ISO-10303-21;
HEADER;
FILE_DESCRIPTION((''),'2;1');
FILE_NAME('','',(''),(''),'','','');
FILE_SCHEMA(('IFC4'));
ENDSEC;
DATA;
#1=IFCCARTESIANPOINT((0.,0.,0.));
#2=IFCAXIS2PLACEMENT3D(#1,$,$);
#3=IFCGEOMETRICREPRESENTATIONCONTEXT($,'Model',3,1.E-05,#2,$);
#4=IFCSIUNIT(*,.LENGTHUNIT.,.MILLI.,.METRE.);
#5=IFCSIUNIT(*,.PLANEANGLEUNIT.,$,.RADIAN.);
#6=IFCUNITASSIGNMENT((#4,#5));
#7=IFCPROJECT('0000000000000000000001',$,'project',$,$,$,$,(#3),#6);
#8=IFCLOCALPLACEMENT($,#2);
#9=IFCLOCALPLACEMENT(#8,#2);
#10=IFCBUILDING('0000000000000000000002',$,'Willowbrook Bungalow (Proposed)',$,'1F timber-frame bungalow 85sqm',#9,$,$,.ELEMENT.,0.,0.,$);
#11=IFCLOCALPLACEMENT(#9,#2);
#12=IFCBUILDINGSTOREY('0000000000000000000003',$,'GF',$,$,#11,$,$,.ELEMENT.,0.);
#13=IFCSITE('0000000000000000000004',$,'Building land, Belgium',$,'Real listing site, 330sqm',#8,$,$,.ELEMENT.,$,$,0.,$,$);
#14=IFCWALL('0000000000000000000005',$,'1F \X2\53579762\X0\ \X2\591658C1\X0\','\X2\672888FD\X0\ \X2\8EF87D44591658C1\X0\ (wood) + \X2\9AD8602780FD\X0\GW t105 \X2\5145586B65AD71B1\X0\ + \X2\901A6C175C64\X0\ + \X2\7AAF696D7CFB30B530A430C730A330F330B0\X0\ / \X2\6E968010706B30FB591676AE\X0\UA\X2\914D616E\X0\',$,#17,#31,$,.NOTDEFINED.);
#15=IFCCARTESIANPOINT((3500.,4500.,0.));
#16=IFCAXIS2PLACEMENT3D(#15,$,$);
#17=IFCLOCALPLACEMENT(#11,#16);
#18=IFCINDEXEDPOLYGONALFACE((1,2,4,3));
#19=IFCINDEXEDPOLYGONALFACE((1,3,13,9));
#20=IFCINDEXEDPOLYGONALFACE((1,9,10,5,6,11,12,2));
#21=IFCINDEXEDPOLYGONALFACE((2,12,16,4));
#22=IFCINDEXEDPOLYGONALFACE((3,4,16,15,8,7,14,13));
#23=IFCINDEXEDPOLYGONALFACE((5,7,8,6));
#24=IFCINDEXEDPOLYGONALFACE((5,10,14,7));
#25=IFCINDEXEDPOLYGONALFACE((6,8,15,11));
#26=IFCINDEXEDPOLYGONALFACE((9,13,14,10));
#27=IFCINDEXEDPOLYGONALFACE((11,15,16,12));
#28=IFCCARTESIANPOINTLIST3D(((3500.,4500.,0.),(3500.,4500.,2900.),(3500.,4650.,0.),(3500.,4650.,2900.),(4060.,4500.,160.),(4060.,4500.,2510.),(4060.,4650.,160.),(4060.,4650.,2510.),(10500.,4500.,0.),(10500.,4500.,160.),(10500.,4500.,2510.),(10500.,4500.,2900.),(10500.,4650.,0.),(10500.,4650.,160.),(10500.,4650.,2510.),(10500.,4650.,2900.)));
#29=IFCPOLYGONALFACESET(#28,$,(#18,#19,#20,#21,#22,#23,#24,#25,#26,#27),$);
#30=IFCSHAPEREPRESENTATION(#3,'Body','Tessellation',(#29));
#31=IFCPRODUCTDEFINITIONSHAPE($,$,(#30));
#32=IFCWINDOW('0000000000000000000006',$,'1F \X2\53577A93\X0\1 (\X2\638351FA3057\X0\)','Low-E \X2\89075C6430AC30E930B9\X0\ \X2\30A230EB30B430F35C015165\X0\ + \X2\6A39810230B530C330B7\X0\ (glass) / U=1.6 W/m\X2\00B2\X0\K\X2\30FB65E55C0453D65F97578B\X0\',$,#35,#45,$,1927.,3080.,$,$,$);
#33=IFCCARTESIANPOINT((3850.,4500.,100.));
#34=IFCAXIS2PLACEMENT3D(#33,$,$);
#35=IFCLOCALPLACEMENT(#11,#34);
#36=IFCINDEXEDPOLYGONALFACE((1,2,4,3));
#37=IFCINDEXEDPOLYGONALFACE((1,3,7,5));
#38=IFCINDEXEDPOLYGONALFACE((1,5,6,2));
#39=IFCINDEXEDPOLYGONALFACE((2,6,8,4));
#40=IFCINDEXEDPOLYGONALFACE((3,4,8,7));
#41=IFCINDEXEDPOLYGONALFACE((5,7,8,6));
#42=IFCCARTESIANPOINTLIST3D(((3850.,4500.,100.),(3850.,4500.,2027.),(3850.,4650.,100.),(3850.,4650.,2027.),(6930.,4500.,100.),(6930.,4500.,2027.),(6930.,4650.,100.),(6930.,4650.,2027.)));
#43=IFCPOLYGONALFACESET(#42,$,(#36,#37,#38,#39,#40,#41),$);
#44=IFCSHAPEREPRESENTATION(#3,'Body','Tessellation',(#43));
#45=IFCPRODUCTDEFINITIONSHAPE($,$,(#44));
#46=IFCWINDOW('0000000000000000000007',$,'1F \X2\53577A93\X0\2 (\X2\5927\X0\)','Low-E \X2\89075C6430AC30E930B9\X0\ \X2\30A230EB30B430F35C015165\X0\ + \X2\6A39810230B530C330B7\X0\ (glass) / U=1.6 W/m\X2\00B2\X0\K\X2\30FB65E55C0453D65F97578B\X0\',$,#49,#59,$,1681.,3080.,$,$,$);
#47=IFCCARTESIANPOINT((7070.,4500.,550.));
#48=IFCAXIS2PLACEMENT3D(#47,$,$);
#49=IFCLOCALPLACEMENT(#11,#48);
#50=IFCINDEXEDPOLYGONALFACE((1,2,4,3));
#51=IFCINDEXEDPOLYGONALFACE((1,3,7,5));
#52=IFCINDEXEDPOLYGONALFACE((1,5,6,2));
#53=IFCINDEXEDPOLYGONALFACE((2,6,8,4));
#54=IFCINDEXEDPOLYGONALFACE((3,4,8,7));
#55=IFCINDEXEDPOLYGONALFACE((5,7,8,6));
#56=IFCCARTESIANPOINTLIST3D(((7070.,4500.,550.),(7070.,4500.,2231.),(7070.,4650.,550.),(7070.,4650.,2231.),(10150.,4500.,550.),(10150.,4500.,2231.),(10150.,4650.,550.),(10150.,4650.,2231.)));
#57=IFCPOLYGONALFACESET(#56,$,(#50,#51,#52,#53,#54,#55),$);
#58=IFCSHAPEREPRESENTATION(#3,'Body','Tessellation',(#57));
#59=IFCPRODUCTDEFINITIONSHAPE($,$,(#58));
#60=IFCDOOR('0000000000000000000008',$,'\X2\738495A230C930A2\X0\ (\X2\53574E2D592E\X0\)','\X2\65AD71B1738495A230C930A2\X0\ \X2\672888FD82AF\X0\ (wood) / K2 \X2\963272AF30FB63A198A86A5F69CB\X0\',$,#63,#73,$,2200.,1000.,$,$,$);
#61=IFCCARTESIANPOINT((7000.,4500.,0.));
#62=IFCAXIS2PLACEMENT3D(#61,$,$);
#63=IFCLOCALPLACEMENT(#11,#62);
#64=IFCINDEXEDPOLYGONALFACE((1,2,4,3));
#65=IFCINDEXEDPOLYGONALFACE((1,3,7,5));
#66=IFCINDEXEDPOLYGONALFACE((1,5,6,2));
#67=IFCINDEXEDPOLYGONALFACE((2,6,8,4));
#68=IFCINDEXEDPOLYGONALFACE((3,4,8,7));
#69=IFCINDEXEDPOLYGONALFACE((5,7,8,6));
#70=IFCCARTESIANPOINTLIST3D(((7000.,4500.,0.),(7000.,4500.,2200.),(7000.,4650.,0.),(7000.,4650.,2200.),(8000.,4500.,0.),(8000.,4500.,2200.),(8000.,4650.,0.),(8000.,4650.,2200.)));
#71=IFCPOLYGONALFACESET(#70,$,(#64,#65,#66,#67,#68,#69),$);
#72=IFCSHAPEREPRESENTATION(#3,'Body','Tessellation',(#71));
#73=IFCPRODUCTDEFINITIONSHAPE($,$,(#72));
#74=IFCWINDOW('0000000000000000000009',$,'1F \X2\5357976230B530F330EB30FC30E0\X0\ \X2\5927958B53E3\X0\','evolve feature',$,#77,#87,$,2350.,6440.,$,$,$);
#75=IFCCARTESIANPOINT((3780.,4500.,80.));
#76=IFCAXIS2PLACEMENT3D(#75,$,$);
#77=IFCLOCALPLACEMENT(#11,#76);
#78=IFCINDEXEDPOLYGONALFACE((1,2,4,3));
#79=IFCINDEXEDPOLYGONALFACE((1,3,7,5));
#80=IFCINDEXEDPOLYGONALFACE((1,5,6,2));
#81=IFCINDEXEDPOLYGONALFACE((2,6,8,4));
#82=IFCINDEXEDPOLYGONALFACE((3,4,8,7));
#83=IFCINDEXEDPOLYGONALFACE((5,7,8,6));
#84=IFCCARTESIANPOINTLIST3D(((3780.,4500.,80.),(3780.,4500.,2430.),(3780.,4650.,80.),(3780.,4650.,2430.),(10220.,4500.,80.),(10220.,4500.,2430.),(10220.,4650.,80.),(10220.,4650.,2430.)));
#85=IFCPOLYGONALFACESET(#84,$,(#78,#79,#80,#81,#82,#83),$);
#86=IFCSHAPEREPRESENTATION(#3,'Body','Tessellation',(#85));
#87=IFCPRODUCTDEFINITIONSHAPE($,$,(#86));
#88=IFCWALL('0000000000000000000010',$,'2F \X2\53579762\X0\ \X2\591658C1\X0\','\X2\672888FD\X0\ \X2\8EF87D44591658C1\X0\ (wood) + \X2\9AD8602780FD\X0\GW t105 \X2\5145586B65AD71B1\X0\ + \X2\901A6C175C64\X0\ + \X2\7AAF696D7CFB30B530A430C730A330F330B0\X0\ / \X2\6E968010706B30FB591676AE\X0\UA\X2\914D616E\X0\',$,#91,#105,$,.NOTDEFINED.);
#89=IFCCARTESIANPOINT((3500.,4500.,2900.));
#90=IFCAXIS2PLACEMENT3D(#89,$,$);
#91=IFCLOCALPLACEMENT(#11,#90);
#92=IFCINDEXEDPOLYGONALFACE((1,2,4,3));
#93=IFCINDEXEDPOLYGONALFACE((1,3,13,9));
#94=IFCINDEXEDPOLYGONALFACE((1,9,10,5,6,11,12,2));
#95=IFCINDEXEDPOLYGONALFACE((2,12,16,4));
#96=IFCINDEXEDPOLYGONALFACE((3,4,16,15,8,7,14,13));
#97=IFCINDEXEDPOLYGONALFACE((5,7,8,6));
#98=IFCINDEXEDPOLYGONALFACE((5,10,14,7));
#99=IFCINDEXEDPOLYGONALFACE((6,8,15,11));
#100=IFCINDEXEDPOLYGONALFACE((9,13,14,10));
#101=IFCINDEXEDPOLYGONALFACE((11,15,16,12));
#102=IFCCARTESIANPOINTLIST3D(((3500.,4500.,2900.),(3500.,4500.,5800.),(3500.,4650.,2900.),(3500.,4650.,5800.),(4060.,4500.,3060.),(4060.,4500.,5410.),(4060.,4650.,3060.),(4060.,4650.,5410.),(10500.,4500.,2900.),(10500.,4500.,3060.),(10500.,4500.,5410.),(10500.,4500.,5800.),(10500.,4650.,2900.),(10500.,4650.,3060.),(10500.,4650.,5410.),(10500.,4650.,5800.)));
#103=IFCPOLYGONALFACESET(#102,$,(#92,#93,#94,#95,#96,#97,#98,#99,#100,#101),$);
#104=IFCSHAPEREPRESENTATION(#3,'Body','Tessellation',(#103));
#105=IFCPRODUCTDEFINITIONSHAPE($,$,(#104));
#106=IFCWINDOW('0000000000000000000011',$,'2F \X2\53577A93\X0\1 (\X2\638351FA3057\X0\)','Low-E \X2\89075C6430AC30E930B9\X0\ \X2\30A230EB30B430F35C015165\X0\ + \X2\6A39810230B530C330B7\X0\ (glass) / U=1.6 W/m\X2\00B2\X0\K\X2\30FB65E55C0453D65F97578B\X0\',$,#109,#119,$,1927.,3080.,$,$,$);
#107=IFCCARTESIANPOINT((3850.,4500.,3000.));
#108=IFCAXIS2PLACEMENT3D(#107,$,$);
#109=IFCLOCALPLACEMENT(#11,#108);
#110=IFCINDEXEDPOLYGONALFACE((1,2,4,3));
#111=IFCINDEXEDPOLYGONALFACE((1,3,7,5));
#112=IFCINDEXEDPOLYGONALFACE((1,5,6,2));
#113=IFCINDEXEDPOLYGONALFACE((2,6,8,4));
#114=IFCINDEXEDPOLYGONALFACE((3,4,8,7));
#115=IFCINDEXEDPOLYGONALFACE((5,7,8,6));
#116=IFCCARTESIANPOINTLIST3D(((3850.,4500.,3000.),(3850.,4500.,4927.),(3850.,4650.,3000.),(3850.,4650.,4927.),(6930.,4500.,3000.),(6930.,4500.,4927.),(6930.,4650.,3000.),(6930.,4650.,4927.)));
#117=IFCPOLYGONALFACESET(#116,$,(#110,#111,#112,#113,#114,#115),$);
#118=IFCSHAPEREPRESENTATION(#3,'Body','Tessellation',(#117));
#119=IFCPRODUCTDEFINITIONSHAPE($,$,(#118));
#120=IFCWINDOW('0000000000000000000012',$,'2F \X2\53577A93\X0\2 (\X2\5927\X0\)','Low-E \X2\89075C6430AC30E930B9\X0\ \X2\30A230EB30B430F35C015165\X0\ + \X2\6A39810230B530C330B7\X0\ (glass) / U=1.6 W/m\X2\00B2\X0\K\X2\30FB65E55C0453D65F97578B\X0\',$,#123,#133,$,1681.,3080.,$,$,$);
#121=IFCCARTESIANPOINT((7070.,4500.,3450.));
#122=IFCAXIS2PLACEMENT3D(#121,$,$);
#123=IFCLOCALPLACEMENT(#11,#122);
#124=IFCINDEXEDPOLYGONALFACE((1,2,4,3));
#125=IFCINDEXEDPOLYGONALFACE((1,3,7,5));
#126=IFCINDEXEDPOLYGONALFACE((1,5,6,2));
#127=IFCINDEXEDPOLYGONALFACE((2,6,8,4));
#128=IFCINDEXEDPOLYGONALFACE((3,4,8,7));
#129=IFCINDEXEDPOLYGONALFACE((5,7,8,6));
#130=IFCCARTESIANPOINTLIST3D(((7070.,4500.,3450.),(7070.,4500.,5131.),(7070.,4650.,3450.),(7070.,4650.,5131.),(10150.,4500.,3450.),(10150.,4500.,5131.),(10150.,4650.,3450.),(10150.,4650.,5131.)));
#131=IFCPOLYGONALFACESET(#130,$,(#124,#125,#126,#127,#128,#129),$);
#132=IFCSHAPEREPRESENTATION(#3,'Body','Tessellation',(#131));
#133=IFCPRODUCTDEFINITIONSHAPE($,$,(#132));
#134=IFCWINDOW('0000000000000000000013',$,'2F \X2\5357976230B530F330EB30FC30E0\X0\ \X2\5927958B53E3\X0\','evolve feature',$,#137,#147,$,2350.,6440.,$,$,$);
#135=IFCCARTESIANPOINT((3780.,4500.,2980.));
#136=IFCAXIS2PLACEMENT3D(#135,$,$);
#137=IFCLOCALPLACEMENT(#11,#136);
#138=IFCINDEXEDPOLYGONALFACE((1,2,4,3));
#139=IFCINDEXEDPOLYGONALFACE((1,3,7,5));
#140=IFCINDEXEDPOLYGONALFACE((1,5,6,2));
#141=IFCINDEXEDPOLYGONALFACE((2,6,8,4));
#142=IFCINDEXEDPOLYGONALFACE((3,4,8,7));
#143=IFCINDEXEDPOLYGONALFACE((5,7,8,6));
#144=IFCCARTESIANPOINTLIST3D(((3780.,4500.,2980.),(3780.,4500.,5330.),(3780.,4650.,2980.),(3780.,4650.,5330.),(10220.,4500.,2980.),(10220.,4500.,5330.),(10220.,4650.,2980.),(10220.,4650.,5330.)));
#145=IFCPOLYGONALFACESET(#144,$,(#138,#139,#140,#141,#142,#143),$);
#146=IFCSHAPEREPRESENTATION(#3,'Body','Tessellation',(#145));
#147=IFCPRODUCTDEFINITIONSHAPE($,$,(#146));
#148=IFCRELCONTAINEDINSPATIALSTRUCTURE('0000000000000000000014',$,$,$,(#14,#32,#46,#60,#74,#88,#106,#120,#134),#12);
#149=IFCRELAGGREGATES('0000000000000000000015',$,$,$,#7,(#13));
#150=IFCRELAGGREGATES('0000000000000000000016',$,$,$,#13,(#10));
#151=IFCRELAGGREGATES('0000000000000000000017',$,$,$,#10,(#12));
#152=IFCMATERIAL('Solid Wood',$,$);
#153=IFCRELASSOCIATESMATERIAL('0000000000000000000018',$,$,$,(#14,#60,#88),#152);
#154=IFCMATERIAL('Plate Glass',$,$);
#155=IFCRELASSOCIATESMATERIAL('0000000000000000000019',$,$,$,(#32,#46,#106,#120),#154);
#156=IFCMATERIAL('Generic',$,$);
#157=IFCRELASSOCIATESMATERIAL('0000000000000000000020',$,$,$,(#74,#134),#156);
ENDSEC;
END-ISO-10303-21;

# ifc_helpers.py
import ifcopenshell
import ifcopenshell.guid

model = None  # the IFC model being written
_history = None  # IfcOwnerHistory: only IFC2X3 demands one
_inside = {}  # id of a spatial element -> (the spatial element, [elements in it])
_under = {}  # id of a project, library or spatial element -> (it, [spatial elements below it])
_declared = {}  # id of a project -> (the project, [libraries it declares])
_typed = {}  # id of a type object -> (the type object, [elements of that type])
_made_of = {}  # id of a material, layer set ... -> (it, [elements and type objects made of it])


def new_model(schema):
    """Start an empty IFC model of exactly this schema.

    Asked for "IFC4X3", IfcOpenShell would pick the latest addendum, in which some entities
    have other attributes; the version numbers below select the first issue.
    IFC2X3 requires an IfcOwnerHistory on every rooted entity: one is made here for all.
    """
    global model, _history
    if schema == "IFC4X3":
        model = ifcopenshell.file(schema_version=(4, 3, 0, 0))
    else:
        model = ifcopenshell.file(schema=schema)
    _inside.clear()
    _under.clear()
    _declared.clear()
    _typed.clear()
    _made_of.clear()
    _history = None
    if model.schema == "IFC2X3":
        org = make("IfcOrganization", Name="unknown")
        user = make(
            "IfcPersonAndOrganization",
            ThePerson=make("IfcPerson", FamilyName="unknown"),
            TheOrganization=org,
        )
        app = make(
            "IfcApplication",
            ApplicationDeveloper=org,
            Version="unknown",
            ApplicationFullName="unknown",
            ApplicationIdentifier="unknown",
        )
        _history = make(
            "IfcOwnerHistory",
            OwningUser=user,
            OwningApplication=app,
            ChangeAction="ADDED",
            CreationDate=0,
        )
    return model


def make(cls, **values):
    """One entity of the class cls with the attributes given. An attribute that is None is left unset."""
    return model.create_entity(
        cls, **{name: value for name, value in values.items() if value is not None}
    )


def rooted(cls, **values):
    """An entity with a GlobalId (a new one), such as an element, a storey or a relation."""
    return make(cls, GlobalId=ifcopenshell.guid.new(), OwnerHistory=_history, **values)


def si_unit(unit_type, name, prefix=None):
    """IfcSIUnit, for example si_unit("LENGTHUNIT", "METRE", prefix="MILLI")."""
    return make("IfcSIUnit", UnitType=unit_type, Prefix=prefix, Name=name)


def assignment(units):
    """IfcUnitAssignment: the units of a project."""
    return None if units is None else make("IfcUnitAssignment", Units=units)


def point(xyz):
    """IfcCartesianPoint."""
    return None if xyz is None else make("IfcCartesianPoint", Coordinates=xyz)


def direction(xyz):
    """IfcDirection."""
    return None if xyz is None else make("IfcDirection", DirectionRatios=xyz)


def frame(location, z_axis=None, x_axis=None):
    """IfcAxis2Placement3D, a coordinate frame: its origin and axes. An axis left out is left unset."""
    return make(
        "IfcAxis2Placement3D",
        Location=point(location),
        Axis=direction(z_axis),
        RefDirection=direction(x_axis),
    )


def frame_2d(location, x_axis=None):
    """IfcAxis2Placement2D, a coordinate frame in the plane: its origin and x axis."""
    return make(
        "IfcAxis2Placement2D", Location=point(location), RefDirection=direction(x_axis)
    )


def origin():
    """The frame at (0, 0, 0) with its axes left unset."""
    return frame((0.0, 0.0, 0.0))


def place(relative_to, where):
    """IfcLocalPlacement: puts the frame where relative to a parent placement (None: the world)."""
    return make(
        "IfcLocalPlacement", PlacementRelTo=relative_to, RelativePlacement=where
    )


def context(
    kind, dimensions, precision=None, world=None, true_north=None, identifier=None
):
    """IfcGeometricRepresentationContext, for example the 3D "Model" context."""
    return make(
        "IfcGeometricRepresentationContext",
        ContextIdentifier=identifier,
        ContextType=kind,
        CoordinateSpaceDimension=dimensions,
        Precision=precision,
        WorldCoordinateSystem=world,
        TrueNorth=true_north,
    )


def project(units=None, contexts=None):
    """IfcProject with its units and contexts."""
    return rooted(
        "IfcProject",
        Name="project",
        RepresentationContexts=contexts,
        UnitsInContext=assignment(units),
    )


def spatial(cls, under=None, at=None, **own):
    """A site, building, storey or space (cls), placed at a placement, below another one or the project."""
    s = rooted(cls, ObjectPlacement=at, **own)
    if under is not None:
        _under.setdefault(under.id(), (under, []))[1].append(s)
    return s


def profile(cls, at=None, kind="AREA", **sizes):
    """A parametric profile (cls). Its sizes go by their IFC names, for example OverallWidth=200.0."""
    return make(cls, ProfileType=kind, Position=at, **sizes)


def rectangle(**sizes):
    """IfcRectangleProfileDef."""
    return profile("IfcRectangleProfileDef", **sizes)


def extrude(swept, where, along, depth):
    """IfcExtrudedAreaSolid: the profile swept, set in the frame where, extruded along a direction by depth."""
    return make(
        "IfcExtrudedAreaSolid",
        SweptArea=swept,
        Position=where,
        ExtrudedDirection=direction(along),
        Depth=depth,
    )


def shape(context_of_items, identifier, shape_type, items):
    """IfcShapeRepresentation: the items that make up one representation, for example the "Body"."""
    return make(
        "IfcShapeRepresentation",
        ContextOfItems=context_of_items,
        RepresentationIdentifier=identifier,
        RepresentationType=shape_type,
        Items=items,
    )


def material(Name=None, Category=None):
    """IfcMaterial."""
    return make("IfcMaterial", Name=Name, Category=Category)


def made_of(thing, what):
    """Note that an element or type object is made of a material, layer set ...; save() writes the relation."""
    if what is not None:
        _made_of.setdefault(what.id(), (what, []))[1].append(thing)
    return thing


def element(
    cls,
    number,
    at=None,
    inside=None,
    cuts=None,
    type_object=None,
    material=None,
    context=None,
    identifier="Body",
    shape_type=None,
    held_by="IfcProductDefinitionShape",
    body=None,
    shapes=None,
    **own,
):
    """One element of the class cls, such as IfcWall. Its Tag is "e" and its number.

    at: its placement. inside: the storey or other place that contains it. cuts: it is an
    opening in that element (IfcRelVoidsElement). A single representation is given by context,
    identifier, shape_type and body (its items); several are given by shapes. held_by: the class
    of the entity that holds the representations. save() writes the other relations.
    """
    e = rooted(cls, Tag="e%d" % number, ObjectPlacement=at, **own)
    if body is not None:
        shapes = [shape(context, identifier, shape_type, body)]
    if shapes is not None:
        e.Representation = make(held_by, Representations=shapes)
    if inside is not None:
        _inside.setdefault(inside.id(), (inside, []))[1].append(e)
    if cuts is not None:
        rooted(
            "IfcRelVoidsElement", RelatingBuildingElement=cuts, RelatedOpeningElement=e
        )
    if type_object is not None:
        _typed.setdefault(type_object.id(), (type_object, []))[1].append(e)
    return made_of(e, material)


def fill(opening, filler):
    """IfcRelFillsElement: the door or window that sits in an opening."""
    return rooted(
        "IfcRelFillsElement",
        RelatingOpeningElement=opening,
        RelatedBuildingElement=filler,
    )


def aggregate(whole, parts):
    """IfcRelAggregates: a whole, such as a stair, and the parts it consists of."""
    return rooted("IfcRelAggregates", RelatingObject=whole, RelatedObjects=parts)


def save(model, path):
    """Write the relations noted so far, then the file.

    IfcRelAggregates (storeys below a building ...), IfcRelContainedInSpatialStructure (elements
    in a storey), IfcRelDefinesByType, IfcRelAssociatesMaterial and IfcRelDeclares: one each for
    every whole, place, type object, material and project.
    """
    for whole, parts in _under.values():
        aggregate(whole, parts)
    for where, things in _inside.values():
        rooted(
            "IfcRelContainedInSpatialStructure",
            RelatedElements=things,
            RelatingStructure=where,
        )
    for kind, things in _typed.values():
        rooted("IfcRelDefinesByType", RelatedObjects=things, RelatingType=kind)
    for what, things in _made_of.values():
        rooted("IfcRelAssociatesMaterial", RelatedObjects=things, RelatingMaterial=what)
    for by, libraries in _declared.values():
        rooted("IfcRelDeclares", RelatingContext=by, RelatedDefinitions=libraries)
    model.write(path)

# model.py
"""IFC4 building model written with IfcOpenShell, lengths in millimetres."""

from ifc_helpers import new_model, si_unit, frame, frame_2d, origin, place, context, project, spatial, rectangle, extrude, material, element, fill, save


model = new_model("IFC4")

# Units and contexts
model_context = context("Model", 3, precision=1e-05, world=origin())
ifc_project = project(units=[si_unit("LENGTHUNIT", "METRE", prefix="MILLI"), si_unit("PLANEANGLEUNIT", "RADIAN")], contexts=[model_context])

# Site, building, storey
site_placement = place(None, origin())
site = spatial("IfcSite", under=ifc_project, at=site_placement, Name="Building land, Belgium", ObjectType="Real listing site, 330sqm", CompositionType="ELEMENT", RefElevation=0.0)
building_placement = place(site_placement, origin())
building = spatial("IfcBuilding", under=site, at=building_placement, Name="Willowbrook Bungalow (Proposed)", ObjectType="1F timber-frame bungalow 85sqm", CompositionType="ELEMENT", ElevationOfRefHeight=0.0, ElevationOfTerrain=0.0)
storey_placement = place(building_placement, origin())
storey = spatial("IfcBuildingStorey", under=building, at=storey_placement, Name="GF", CompositionType="ELEMENT", Elevation=0.0)

# Shared definitions
ifc_material_1 = material(Name="Solid Wood")
ifc_material_2 = material(Name="Generic")

# Wall, openings, windows, door
wall_1_placement = place(storey_placement, frame((3500.0, 4500.0, 0.0)))
wall_1 = element("IfcWall", 1, at=wall_1_placement, inside=storey, material=ifc_material_1, Name="1F 南面 外壁", Description="木製 軸組外壁 (wood) + 高性能GW t105 充填断熱 + 通気層 + 窯業系サイディング / 準耐火・外皮UA配慮", PredefinedType="NOTDEFINED", context=model_context, shape_type="SweptSolid", body=[
    extrude(rectangle(XDim=7000.0, YDim=150.0, at=frame_2d((3500.0, 75.0))), frame((3500.0, 4500.0, 0.0)), (0.0, 0.0, 1.0), 2900.0),
])
opening_1_placement = place(storey_placement, frame((3850.0, 4500.0, 100.0)))
opening_1 = element("IfcOpeningElement", 2, at=opening_1_placement, cuts=wall_1, PredefinedType="NOTDEFINED", context=model_context, shape_type="SweptSolid", body=[
    extrude(rectangle(XDim=3080.0, YDim=150.0, at=frame_2d((1540.0, 75.0))), frame((3850.0, 4500.0, 100.0)), (0.0, 0.0, 1.0), 1927.0),
])
opening_2_placement = place(storey_placement, frame((7070.0, 4500.0, 550.0)))
opening_2 = element("IfcOpeningElement", 3, at=opening_2_placement, cuts=wall_1, PredefinedType="NOTDEFINED", context=model_context, shape_type="SweptSolid", body=[
    extrude(rectangle(XDim=3080.0, YDim=150.0, at=frame_2d((1540.0, 75.0))), frame((7070.0, 4500.0, 550.0)), (0.0, 0.0, 1.0), 1681.0),
])
opening_3_placement = place(storey_placement, frame((7000.0, 4500.0, 0.0)))
opening_3 = element("IfcOpeningElement", 4, at=opening_3_placement, cuts=wall_1, PredefinedType="NOTDEFINED", context=model_context, shape_type="SweptSolid", body=[
    extrude(rectangle(XDim=1000.0, YDim=150.0, at=frame_2d((500.0, 75.0))), frame((7000.0, 4500.0, 0.0)), (0.0, 0.0, 1.0), 2200.0),
])
opening_4_placement = place(storey_placement, frame((3780.0, 4500.0, 80.0)))
opening_4 = element("IfcOpeningElement", 5, at=opening_4_placement, cuts=wall_1, PredefinedType="NOTDEFINED", context=model_context, shape_type="SweptSolid", body=[
    extrude(rectangle(XDim=6440.0, YDim=150.0, at=frame_2d((3220.0, 75.0))), frame((3780.0, 4500.0, 80.0)), (0.0, 0.0, 1.0), 2350.0),
])
ifc_material_3 = material(Name="Plate Glass")
window_1_placement = place(storey_placement, frame((3850.0, 4500.0, 100.0)))
window_1 = element("IfcWindow", 6, at=window_1_placement, inside=storey, material=ifc_material_3, Name="1F 南窓1 (掃出し)", Description="Low-E 複層ガラス アルゴン封入 + 樹脂サッシ (glass) / U=1.6 W/m²K・日射取得型", OverallHeight=1927.0, OverallWidth=3080.0, context=model_context, shape_type="SweptSolid", body=[
    extrude(rectangle(XDim=3080.0, YDim=150.0, at=frame_2d((1540.0, 75.0))), frame((3850.0, 4500.0, 100.0)), (0.0, 0.0, 1.0), 1927.0),
])
fill(opening_1, window_1)
window_2_placement = place(storey_placement, frame((7070.0, 4500.0, 550.0)))
window_2 = element("IfcWindow", 7, at=window_2_placement, inside=storey, material=ifc_material_3, Name="1F 南窓2 (大)", Description="Low-E 複層ガラス アルゴン封入 + 樹脂サッシ (glass) / U=1.6 W/m²K・日射取得型", OverallHeight=1681.0, OverallWidth=3080.0, context=model_context, shape_type="SweptSolid", body=[
    extrude(rectangle(XDim=3080.0, YDim=150.0, at=frame_2d((1540.0, 75.0))), frame((7070.0, 4500.0, 550.0)), (0.0, 0.0, 1.0), 1681.0),
])
fill(opening_2, window_2)
door_placement = place(storey_placement, frame((7000.0, 4500.0, 0.0)))
door = element("IfcDoor", 8, at=door_placement, inside=storey, material=ifc_material_1, Name="玄関ドア (南中央)", Description="断熱玄関ドア 木製芯 (wood) / K2 防犯・採風機構", OverallHeight=2200.0, OverallWidth=1000.0, context=model_context, shape_type="SweptSolid", body=[
    extrude(rectangle(XDim=1000.0, YDim=150.0, at=frame_2d((500.0, 75.0))), frame((7000.0, 4500.0, 0.0)), (0.0, 0.0, 1.0), 2200.0),
])
fill(opening_3, door)
window_3_placement = place(storey_placement, frame((3780.0, 4500.0, 80.0)))
window_3 = element("IfcWindow", 9, at=window_3_placement, inside=storey, material=ifc_material_2, Name="1F 南面サンルーム 大開口", Description="evolve feature", OverallHeight=2350.0, OverallWidth=6440.0, context=model_context, shape_type="SweptSolid", body=[
    extrude(rectangle(XDim=6440.0, YDim=150.0, at=frame_2d((3220.0, 75.0))), frame((3780.0, 4500.0, 80.0)), (0.0, 0.0, 1.0), 2350.0),
])
fill(opening_4, window_3)

# Wall, openings, windows
wall_2_placement = place(storey_placement, frame((3500.0, 4500.0, 2900.0)))
wall_2 = element("IfcWall", 10, at=wall_2_placement, inside=storey, material=ifc_material_1, Name="2F 南面 外壁", Description="木製 軸組外壁 (wood) + 高性能GW t105 充填断熱 + 通気層 + 窯業系サイディング / 準耐火・外皮UA配慮", PredefinedType="NOTDEFINED", context=model_context, shape_type="SweptSolid", body=[
    extrude(rectangle(XDim=7000.0, YDim=150.0, at=frame_2d((3500.0, 75.0))), frame((3500.0, 4500.0, 2900.0)), (0.0, 0.0, 1.0), 2900.0),
])
opening_5_placement = place(storey_placement, frame((3850.0, 4500.0, 3000.0)))
opening_5 = element("IfcOpeningElement", 11, at=opening_5_placement, cuts=wall_2, PredefinedType="NOTDEFINED", context=model_context, shape_type="SweptSolid", body=[
    extrude(rectangle(XDim=3080.0, YDim=150.0, at=frame_2d((1540.0, 75.0))), frame((3850.0, 4500.0, 3000.0)), (0.0, 0.0, 1.0), 1927.0),
])
opening_6_placement = place(storey_placement, frame((7070.0, 4500.0, 3450.0)))
opening_6 = element("IfcOpeningElement", 12, at=opening_6_placement, cuts=wall_2, PredefinedType="NOTDEFINED", context=model_context, shape_type="SweptSolid", body=[
    extrude(rectangle(XDim=3080.0, YDim=150.0, at=frame_2d((1540.0, 75.0))), frame((7070.0, 4500.0, 3450.0)), (0.0, 0.0, 1.0), 1681.0),
])
opening_7_placement = place(storey_placement, frame((3780.0, 4500.0, 2980.0)))
opening_7 = element("IfcOpeningElement", 13, at=opening_7_placement, cuts=wall_2, PredefinedType="NOTDEFINED", context=model_context, shape_type="SweptSolid", body=[
    extrude(rectangle(XDim=6440.0, YDim=150.0, at=frame_2d((3220.0, 75.0))), frame((3780.0, 4500.0, 2980.0)), (0.0, 0.0, 1.0), 2350.0),
])
window_4_placement = place(storey_placement, frame((3850.0, 4500.0, 3000.0)))
window_4 = element("IfcWindow", 14, at=window_4_placement, inside=storey, material=ifc_material_3, Name="2F 南窓1 (掃出し)", Description="Low-E 複層ガラス アルゴン封入 + 樹脂サッシ (glass) / U=1.6 W/m²K・日射取得型", OverallHeight=1927.0, OverallWidth=3080.0, context=model_context, shape_type="SweptSolid", body=[
    extrude(rectangle(XDim=3080.0, YDim=150.0, at=frame_2d((1540.0, 75.0))), frame((3850.0, 4500.0, 3000.0)), (0.0, 0.0, 1.0), 1927.0),
])
fill(opening_5, window_4)
window_5_placement = place(storey_placement, frame((7070.0, 4500.0, 3450.0)))
window_5 = element("IfcWindow", 15, at=window_5_placement, inside=storey, material=ifc_material_3, Name="2F 南窓2 (大)", Description="Low-E 複層ガラス アルゴン封入 + 樹脂サッシ (glass) / U=1.6 W/m²K・日射取得型", OverallHeight=1681.0, OverallWidth=3080.0, context=model_context, shape_type="SweptSolid", body=[
    extrude(rectangle(XDim=3080.0, YDim=150.0, at=frame_2d((1540.0, 75.0))), frame((7070.0, 4500.0, 3450.0)), (0.0, 0.0, 1.0), 1681.0),
])
fill(opening_6, window_5)
window_6_placement = place(storey_placement, frame((3780.0, 4500.0, 2980.0)))
window_6 = element("IfcWindow", 16, at=window_6_placement, inside=storey, material=ifc_material_2, Name="2F 南面サンルーム 大開口", Description="evolve feature", OverallHeight=2350.0, OverallWidth=6440.0, context=model_context, shape_type="SweptSolid", body=[
    extrude(rectangle(XDim=6440.0, YDim=150.0, at=frame_2d((3220.0, 75.0))), frame((3780.0, 4500.0, 2980.0)), (0.0, 0.0, 1.0), 2350.0),
])
fill(opening_7, window_6)

save(model, "model.ifc")
